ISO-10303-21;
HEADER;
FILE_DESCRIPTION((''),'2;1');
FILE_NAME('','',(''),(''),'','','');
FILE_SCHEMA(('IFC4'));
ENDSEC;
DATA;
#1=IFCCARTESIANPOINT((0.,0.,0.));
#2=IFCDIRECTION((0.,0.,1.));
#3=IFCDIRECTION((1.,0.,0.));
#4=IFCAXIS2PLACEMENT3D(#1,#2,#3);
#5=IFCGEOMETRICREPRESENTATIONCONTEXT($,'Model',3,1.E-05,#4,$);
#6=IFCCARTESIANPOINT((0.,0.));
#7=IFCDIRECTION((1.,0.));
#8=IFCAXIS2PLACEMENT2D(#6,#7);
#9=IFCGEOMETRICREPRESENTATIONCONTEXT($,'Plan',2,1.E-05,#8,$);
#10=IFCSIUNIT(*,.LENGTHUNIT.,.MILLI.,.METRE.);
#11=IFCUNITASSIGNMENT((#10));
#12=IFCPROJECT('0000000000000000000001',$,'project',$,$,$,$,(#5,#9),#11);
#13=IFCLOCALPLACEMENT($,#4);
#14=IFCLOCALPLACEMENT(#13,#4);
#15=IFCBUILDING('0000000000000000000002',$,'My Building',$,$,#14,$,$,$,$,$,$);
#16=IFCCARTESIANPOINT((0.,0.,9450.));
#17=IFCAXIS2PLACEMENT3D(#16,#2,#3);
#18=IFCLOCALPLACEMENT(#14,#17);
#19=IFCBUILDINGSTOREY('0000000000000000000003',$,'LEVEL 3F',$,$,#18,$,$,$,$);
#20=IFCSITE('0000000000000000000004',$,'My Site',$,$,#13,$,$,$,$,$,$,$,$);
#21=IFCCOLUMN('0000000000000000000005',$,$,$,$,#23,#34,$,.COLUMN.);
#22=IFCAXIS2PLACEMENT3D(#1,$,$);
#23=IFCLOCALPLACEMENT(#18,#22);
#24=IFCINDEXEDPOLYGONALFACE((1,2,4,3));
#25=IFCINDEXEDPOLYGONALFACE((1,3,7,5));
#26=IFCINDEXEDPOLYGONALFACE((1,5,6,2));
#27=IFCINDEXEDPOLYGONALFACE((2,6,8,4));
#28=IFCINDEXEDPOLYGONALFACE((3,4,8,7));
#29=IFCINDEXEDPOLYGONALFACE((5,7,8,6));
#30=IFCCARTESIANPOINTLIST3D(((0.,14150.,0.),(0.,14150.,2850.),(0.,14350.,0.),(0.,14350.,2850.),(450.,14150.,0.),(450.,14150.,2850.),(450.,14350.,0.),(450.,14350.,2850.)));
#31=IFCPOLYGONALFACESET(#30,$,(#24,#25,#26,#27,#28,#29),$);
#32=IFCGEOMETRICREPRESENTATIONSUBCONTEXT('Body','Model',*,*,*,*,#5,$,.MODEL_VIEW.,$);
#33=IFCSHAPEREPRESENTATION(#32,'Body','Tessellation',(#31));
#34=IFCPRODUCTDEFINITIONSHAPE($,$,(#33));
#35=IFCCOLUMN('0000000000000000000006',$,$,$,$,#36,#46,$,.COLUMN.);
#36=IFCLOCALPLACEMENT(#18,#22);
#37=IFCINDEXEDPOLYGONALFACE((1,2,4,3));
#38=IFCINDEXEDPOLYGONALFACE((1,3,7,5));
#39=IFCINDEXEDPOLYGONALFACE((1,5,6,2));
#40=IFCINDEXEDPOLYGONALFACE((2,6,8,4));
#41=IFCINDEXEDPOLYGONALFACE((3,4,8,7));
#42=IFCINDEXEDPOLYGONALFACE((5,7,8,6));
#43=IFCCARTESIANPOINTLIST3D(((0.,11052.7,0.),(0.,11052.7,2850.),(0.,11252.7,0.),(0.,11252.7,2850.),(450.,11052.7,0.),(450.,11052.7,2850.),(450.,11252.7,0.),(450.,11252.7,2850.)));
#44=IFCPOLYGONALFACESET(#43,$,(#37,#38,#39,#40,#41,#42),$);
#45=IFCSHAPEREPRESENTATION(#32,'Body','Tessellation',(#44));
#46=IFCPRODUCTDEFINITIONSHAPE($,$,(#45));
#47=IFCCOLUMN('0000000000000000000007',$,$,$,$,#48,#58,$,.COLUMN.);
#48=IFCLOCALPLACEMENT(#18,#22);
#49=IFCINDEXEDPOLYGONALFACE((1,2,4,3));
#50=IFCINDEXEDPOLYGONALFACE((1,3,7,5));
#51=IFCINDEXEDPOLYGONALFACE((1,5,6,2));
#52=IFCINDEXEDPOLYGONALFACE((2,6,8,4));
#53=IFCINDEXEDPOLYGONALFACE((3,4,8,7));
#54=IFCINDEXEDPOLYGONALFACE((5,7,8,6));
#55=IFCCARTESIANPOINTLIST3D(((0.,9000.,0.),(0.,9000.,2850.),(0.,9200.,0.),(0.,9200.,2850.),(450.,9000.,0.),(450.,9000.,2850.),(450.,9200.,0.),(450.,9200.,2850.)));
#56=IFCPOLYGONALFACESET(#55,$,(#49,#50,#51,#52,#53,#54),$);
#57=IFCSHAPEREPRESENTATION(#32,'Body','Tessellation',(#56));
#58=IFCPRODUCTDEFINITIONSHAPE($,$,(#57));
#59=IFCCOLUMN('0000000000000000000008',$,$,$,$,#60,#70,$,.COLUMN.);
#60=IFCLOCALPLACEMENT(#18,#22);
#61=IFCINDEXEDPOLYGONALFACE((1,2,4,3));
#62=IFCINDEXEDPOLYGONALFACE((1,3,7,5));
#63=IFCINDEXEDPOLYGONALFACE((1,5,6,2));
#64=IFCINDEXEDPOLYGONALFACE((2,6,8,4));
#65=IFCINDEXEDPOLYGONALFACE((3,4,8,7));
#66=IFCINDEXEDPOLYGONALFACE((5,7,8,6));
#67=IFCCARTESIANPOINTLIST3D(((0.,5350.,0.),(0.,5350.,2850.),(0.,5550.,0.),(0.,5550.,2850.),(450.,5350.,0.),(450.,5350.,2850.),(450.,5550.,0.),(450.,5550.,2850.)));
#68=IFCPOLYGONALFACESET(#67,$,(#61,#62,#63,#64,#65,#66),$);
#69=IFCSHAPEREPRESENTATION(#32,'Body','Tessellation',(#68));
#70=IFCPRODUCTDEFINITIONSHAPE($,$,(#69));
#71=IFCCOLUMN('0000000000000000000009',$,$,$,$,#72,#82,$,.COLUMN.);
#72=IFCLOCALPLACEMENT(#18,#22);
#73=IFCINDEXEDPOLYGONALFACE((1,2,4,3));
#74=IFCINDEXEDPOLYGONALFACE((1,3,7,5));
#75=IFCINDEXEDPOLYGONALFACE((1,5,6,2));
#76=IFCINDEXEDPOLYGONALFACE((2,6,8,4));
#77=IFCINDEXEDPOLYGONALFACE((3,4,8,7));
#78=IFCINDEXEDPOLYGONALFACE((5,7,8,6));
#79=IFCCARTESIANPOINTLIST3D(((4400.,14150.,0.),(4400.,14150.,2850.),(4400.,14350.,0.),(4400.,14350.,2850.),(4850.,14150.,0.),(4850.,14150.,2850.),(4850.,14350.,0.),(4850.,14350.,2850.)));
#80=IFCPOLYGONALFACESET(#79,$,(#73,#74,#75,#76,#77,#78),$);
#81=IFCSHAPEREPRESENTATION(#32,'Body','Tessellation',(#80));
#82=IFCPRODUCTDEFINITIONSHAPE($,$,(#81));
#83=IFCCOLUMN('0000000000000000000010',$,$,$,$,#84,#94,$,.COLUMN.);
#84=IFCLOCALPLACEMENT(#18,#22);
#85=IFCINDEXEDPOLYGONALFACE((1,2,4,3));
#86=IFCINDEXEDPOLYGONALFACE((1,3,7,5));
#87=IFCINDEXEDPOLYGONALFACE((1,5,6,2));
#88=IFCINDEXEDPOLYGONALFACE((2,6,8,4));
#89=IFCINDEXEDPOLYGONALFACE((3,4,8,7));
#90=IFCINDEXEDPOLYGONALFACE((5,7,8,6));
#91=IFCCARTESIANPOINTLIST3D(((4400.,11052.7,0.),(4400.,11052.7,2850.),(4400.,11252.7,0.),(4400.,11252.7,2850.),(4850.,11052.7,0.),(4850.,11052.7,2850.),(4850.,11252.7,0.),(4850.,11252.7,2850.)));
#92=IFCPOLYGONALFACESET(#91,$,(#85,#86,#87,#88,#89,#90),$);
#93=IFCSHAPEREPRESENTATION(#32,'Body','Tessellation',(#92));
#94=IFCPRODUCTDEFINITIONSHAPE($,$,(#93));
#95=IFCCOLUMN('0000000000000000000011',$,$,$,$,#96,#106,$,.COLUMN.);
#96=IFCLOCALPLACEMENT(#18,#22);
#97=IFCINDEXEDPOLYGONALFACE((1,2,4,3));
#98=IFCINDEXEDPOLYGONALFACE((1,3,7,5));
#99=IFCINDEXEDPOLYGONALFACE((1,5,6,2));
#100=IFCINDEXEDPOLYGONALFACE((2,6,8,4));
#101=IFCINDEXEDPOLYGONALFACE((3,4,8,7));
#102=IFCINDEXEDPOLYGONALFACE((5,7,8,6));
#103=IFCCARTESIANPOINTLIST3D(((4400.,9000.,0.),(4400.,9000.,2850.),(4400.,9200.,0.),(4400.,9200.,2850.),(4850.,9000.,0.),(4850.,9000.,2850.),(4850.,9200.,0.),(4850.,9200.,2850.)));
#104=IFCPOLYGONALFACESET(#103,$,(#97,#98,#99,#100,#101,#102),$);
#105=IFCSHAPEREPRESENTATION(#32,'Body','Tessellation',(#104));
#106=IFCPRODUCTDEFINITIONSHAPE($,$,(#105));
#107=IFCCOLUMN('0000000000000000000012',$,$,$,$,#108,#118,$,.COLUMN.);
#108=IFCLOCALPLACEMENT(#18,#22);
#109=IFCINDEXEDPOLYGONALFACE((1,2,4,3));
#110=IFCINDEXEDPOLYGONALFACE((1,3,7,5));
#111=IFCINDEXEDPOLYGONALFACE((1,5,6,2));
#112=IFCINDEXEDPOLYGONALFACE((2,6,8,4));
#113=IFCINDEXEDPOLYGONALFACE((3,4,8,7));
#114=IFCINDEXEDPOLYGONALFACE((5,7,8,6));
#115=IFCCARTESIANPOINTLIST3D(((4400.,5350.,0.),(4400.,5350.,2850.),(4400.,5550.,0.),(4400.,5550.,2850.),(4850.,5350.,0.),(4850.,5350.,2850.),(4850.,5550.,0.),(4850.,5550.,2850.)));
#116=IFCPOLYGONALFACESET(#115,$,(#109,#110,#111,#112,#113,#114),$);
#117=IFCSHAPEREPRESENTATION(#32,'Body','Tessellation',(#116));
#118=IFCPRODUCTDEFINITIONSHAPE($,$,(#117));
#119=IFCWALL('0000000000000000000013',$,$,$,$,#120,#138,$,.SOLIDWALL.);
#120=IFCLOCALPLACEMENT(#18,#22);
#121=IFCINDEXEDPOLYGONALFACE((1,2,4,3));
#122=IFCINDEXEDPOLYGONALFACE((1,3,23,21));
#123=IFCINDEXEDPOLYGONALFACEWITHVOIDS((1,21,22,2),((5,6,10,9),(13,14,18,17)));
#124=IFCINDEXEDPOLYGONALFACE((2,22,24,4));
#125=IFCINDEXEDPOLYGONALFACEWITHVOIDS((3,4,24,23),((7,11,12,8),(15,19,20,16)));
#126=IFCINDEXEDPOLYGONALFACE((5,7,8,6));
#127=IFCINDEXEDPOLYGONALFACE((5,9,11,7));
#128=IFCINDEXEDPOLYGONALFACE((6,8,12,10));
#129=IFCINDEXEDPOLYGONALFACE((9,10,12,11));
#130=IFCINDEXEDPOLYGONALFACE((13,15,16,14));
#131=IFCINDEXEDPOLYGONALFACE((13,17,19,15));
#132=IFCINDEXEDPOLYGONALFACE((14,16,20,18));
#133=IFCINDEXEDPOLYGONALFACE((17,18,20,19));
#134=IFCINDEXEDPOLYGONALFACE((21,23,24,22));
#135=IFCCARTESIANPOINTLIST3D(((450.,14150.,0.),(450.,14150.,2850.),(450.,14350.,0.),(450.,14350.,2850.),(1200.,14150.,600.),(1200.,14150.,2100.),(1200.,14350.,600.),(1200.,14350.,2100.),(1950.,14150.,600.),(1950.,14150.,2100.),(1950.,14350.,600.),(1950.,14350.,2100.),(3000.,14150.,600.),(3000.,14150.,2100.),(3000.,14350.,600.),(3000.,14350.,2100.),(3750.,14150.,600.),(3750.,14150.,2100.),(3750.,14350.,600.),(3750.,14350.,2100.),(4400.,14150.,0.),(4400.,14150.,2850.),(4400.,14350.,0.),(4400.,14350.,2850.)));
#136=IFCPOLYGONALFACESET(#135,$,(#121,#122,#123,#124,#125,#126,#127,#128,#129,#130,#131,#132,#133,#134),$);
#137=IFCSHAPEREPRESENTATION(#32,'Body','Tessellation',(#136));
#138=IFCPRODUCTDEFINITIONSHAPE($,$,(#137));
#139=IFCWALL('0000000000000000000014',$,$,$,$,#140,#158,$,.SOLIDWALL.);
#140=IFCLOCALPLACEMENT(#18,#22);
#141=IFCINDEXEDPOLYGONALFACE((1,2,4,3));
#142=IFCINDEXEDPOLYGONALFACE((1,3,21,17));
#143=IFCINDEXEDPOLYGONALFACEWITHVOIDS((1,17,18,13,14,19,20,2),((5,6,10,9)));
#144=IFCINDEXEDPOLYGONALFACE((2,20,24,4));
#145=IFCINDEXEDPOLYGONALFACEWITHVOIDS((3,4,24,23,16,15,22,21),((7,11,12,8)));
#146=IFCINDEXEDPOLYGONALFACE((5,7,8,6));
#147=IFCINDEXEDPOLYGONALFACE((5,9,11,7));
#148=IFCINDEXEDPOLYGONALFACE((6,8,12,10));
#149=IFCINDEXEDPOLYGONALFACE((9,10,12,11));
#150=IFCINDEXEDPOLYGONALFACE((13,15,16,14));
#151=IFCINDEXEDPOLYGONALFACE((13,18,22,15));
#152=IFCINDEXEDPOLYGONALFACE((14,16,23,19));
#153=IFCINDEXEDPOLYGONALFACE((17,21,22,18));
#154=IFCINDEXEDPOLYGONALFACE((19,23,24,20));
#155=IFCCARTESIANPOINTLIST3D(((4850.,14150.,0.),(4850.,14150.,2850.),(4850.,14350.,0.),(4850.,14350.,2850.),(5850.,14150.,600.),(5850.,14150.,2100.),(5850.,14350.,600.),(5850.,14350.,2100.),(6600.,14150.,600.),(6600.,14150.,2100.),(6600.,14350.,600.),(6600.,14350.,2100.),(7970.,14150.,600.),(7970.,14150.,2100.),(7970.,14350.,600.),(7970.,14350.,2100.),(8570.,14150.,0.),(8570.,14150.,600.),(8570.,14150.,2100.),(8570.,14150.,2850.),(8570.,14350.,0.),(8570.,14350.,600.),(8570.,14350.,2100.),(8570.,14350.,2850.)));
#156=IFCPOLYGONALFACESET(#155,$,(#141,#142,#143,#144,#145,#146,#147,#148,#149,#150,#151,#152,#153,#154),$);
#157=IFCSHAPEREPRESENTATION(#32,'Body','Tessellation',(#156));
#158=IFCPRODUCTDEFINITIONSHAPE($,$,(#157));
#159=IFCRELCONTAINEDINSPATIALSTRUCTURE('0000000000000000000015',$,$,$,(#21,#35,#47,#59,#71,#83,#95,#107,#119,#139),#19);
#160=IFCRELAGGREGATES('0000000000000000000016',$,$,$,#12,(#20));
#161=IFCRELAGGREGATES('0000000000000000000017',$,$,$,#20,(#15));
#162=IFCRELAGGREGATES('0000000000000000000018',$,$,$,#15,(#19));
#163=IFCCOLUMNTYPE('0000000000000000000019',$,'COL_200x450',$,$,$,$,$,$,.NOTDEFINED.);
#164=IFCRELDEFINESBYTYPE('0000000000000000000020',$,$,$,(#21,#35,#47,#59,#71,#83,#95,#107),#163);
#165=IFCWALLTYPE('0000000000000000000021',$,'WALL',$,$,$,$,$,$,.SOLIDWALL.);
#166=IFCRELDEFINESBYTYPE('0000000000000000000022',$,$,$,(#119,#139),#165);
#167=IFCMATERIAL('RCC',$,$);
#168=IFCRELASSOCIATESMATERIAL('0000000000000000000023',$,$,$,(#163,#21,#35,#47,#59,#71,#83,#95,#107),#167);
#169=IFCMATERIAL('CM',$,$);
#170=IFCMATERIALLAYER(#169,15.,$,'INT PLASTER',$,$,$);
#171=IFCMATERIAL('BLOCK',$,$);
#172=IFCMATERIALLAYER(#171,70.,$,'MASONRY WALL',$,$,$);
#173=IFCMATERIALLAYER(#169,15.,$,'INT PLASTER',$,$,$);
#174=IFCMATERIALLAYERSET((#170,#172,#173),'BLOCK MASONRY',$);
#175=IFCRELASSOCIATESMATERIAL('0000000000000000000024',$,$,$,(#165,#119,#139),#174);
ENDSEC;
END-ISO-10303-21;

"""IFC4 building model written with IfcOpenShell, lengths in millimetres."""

from ifc_helpers import new_model, si_unit, frame, origin_with_axes, origin_2d_with_axis, place, context, subcontext, project, spatial, indexed_curve, rectangle, outline, extrude, material, layer, layer_set, layer_usage, material_profile, profile_set, profile_usage, type_object, element, save


model = new_model("IFC4")

# Units and contexts
model_context = context("Model", 3, precision=1e-05, world=origin_with_axes())
plan_context = context("Plan", 2, precision=1e-05, world=origin_2d_with_axis())
body_context = subcontext(model_context, "Body", "Model", "MODEL_VIEW")
ifc_project = project(units=[si_unit("LENGTHUNIT", "METRE", prefix="MILLI")], contexts=[model_context, plan_context])

# Site, building, storey
site_placement = place(None, origin_with_axes())
site = spatial("IfcSite", under=ifc_project, at=site_placement, Name="My Site")
building_placement = place(site_placement, origin_with_axes())
building = spatial("IfcBuilding", under=site, at=building_placement, Name="My Building")
storey_placement = place(building_placement, frame((0.0, 0.0, 9450.0), z_axis=(0.0, 0.0, 1.0), x_axis=(1.0, 0.0, 0.0)))
storey = spatial("IfcBuildingStorey", under=building, at=storey_placement, Name="LEVEL 3F")

# Columns
ifc_material_1 = material(Name="RCC")
ifc_material_profile = material_profile(ifc_material_1, rectangle(XDim=200.0, YDim=450.0))
ifc_profile_set = profile_set([ifc_material_profile], Name="COL_200x450")
ifc_profile_usage_1 = profile_usage(ifc_profile_set)
column_type = type_object("IfcColumnType", Name="COL_200x450", PredefinedType="NOTDEFINED", material=ifc_profile_set)
column_1_placement = place(storey_placement, frame((225.0, 14250.0, 0.0), z_axis=(0.0, 0.0, 1.0), x_axis=(0.0, -1.0, 0.0)))
element("IfcColumn", 1, at=column_1_placement, inside=storey, type_object=column_type, material=ifc_profile_usage_1, PredefinedType="COLUMN", context=body_context, shape_type="SweptSolid", body=[
    extrude(rectangle(XDim=200.0, YDim=450.0), origin_with_axes(), (0.0, 0.0, 1.0), 2850.0),
])
ifc_profile_usage_2 = profile_usage(ifc_profile_set)
column_2_placement = place(storey_placement, frame((225.0, 11152.7, 0.0), z_axis=(0.0, 0.0, 1.0), x_axis=(0.0, -1.0, 0.0)))
element("IfcColumn", 2, at=column_2_placement, inside=storey, type_object=column_type, material=ifc_profile_usage_2, PredefinedType="COLUMN", context=body_context, shape_type="SweptSolid", body=[
    extrude(rectangle(XDim=200.0, YDim=450.0), origin_with_axes(), (0.0, 0.0, 1.0), 2850.0),
])
ifc_profile_usage_3 = profile_usage(ifc_profile_set)
column_3_placement = place(storey_placement, frame((225.0, 9100.0, 0.0), z_axis=(0.0, 0.0, 1.0), x_axis=(0.0, -1.0, 0.0)))
element("IfcColumn", 3, at=column_3_placement, inside=storey, type_object=column_type, material=ifc_profile_usage_3, PredefinedType="COLUMN", context=body_context, shape_type="SweptSolid", body=[
    extrude(rectangle(XDim=200.0, YDim=450.0), origin_with_axes(), (0.0, 0.0, 1.0), 2850.0),
])
ifc_profile_usage_4 = profile_usage(ifc_profile_set)
column_4_placement = place(storey_placement, frame((225.0, 5450.0, 0.0), z_axis=(0.0, 0.0, 1.0), x_axis=(0.0, -1.0, 0.0)))
element("IfcColumn", 4, at=column_4_placement, inside=storey, type_object=column_type, material=ifc_profile_usage_4, PredefinedType="COLUMN", context=body_context, shape_type="SweptSolid", body=[
    extrude(rectangle(XDim=200.0, YDim=450.0), origin_with_axes(), (0.0, 0.0, 1.0), 2850.0),
])
ifc_profile_usage_5 = profile_usage(ifc_profile_set)
column_5_placement = place(storey_placement, frame((4625.0, 14250.0, 0.0), z_axis=(0.0, 0.0, 1.0), x_axis=(0.0, -1.0, 0.0)))
element("IfcColumn", 5, at=column_5_placement, inside=storey, type_object=column_type, material=ifc_profile_usage_5, PredefinedType="COLUMN", context=body_context, shape_type="SweptSolid", body=[
    extrude(rectangle(XDim=200.0, YDim=450.0), origin_with_axes(), (0.0, 0.0, 1.0), 2850.0),
])
ifc_profile_usage_6 = profile_usage(ifc_profile_set)
column_6_placement = place(storey_placement, frame((4625.0, 11152.7, 0.0), z_axis=(0.0, 0.0, 1.0), x_axis=(0.0, -1.0, 0.0)))
element("IfcColumn", 6, at=column_6_placement, inside=storey, type_object=column_type, material=ifc_profile_usage_6, PredefinedType="COLUMN", context=body_context, shape_type="SweptSolid", body=[
    extrude(rectangle(XDim=200.0, YDim=450.0), origin_with_axes(), (0.0, 0.0, 1.0), 2850.0),
])
ifc_profile_usage_7 = profile_usage(ifc_profile_set)
column_7_placement = place(storey_placement, frame((4625.0, 9100.0, 0.0), z_axis=(0.0, 0.0, 1.0), x_axis=(0.0, -1.0, 0.0)))
element("IfcColumn", 7, at=column_7_placement, inside=storey, type_object=column_type, material=ifc_profile_usage_7, PredefinedType="COLUMN", context=body_context, shape_type="SweptSolid", body=[
    extrude(rectangle(XDim=200.0, YDim=450.0), origin_with_axes(), (0.0, 0.0, 1.0), 2850.0),
])
ifc_profile_usage_8 = profile_usage(ifc_profile_set)
column_8_placement = place(storey_placement, frame((4625.0, 5450.0, 0.0), z_axis=(0.0, 0.0, 1.0), x_axis=(0.0, -1.0, 0.0)))
element("IfcColumn", 8, at=column_8_placement, inside=storey, type_object=column_type, material=ifc_profile_usage_8, PredefinedType="COLUMN", context=body_context, shape_type="SweptSolid", body=[
    extrude(rectangle(XDim=200.0, YDim=450.0), origin_with_axes(), (0.0, 0.0, 1.0), 2850.0),
])

# Walls, openings
ifc_material_2 = material(Name="CM")
ifc_layer_1 = layer(ifc_material_2, 15.0, Name="INT PLASTER")
ifc_material_3 = material(Name="BLOCK")
ifc_layer_2 = layer(ifc_material_3, 70.0, Name="MASONRY WALL")
ifc_layer_3 = layer(ifc_material_2, 15.0, Name="INT PLASTER")
ifc_layer_set = layer_set([ifc_layer_1, ifc_layer_2, ifc_layer_3], Name="BLOCK MASONRY")
ifc_layer_usage_1 = layer_usage(ifc_layer_set, "AXIS2", "POSITIVE", 0.0)
wall_type = type_object("IfcWallType", Name="WALL", PredefinedType="SOLIDWALL", material=ifc_layer_set)
wall_1_placement = place(storey_placement, frame((450.0, 14350.0, 0.0), z_axis=(0.0, 0.0, 1.0), x_axis=(0.0, -1.0, 0.0)))
wall_1 = element("IfcWall", 9, at=wall_1_placement, inside=storey, type_object=wall_type, material=ifc_layer_usage_1, PredefinedType="SOLIDWALL", context=body_context, shape_type="SweptSolid", body=[
    extrude(outline(indexed_curve([(0.0, 0.0), (0.0, 3950.0), (200.0, 3950.0), (200.0, 0.0), (0.0, 0.0)], self_intersect=False)), origin_with_axes(), (0.0, 0.0, 1.0), 2850.0),
])
opening_1_placement = place(wall_1_placement, frame((200.0, 2550.0, 600.0), z_axis=(0.0, 0.0, 1.0), x_axis=(0.0, 1.0, 0.0)))
element("IfcOpeningElement", 10, at=opening_1_placement, cuts=wall_1, PredefinedType="OPENING", context=body_context, shape_type="SweptSolid", body=[
    extrude(outline(indexed_curve([(0.0, 0.0), (0.0, 400.0), (750.0, 400.0), (750.0, 0.0), (0.0, 0.0)], self_intersect=False)), frame((0.0, -100.0, 0.0), z_axis=(0.0, 0.0, 1.0), x_axis=(1.0, 0.0, 0.0)), (0.0, 0.0, 1.0), 1500.0),
])
opening_2_placement = place(wall_1_placement, frame((200.0, 750.0, 600.0), z_axis=(0.0, 0.0, 1.0), x_axis=(0.0, 1.0, 0.0)))
element("IfcOpeningElement", 11, at=opening_2_placement, cuts=wall_1, PredefinedType="OPENING", context=body_context, shape_type="SweptSolid", body=[
    extrude(outline(indexed_curve([(0.0, 0.0), (0.0, 400.0), (750.0, 400.0), (750.0, 0.0), (0.0, 0.0)], self_intersect=False)), frame((0.0, -100.0, 0.0), z_axis=(0.0, 0.0, 1.0), x_axis=(1.0, 0.0, 0.0)), (0.0, 0.0, 1.0), 1500.0),
])
ifc_layer_usage_2 = layer_usage(ifc_layer_set, "AXIS2", "POSITIVE", 0.0)
wall_2_placement = place(storey_placement, frame((4850.0, 14350.0, 0.0), z_axis=(0.0, 0.0, 1.0), x_axis=(0.0, -1.0, 0.0)))
wall_2 = element("IfcWall", 12, at=wall_2_placement, inside=storey, type_object=wall_type, material=ifc_layer_usage_2, PredefinedType="SOLIDWALL", context=body_context, shape_type="SweptSolid", body=[
    extrude(outline(indexed_curve([(0.0, 0.0), (0.0, 3720.0), (200.0, 3720.0), (200.0, 0.0), (0.0, 0.0)], self_intersect=False)), origin_with_axes(), (0.0, 0.0, 1.0), 2850.0),
])
opening_3_placement = place(wall_2_placement, frame((200.0, 1000.0, 600.0), z_axis=(0.0, 0.0, 1.0), x_axis=(0.0, 1.0, 0.0)))
element("IfcOpeningElement", 13, at=opening_3_placement, cuts=wall_2, PredefinedType="OPENING", context=body_context, shape_type="SweptSolid", body=[
    extrude(outline(indexed_curve([(0.0, 0.0), (0.0, 400.0), (750.0, 400.0), (750.0, 0.0), (0.0, 0.0)], self_intersect=False)), frame((0.0, -100.0, 0.0), z_axis=(0.0, 0.0, 1.0), x_axis=(1.0, 0.0, 0.0)), (0.0, 0.0, 1.0), 1500.0),
])
opening_4_placement = place(wall_2_placement, frame((200.0, 3120.0, 600.0), z_axis=(0.0, 0.0, 1.0), x_axis=(0.0, 1.0, 0.0)))
element("IfcOpeningElement", 14, at=opening_4_placement, cuts=wall_2, PredefinedType="OPENING", context=body_context, shape_type="SweptSolid", body=[
    extrude(outline(indexed_curve([(0.0, 0.0), (0.0, 400.0), (750.0, 400.0), (750.0, 0.0), (0.0, 0.0)], self_intersect=False)), frame((0.0, -100.0, 0.0), z_axis=(0.0, 0.0, 1.0), x_axis=(1.0, 0.0, 0.0)), (0.0, 0.0, 1.0), 1500.0),
])

save(model, "model.ifc")
